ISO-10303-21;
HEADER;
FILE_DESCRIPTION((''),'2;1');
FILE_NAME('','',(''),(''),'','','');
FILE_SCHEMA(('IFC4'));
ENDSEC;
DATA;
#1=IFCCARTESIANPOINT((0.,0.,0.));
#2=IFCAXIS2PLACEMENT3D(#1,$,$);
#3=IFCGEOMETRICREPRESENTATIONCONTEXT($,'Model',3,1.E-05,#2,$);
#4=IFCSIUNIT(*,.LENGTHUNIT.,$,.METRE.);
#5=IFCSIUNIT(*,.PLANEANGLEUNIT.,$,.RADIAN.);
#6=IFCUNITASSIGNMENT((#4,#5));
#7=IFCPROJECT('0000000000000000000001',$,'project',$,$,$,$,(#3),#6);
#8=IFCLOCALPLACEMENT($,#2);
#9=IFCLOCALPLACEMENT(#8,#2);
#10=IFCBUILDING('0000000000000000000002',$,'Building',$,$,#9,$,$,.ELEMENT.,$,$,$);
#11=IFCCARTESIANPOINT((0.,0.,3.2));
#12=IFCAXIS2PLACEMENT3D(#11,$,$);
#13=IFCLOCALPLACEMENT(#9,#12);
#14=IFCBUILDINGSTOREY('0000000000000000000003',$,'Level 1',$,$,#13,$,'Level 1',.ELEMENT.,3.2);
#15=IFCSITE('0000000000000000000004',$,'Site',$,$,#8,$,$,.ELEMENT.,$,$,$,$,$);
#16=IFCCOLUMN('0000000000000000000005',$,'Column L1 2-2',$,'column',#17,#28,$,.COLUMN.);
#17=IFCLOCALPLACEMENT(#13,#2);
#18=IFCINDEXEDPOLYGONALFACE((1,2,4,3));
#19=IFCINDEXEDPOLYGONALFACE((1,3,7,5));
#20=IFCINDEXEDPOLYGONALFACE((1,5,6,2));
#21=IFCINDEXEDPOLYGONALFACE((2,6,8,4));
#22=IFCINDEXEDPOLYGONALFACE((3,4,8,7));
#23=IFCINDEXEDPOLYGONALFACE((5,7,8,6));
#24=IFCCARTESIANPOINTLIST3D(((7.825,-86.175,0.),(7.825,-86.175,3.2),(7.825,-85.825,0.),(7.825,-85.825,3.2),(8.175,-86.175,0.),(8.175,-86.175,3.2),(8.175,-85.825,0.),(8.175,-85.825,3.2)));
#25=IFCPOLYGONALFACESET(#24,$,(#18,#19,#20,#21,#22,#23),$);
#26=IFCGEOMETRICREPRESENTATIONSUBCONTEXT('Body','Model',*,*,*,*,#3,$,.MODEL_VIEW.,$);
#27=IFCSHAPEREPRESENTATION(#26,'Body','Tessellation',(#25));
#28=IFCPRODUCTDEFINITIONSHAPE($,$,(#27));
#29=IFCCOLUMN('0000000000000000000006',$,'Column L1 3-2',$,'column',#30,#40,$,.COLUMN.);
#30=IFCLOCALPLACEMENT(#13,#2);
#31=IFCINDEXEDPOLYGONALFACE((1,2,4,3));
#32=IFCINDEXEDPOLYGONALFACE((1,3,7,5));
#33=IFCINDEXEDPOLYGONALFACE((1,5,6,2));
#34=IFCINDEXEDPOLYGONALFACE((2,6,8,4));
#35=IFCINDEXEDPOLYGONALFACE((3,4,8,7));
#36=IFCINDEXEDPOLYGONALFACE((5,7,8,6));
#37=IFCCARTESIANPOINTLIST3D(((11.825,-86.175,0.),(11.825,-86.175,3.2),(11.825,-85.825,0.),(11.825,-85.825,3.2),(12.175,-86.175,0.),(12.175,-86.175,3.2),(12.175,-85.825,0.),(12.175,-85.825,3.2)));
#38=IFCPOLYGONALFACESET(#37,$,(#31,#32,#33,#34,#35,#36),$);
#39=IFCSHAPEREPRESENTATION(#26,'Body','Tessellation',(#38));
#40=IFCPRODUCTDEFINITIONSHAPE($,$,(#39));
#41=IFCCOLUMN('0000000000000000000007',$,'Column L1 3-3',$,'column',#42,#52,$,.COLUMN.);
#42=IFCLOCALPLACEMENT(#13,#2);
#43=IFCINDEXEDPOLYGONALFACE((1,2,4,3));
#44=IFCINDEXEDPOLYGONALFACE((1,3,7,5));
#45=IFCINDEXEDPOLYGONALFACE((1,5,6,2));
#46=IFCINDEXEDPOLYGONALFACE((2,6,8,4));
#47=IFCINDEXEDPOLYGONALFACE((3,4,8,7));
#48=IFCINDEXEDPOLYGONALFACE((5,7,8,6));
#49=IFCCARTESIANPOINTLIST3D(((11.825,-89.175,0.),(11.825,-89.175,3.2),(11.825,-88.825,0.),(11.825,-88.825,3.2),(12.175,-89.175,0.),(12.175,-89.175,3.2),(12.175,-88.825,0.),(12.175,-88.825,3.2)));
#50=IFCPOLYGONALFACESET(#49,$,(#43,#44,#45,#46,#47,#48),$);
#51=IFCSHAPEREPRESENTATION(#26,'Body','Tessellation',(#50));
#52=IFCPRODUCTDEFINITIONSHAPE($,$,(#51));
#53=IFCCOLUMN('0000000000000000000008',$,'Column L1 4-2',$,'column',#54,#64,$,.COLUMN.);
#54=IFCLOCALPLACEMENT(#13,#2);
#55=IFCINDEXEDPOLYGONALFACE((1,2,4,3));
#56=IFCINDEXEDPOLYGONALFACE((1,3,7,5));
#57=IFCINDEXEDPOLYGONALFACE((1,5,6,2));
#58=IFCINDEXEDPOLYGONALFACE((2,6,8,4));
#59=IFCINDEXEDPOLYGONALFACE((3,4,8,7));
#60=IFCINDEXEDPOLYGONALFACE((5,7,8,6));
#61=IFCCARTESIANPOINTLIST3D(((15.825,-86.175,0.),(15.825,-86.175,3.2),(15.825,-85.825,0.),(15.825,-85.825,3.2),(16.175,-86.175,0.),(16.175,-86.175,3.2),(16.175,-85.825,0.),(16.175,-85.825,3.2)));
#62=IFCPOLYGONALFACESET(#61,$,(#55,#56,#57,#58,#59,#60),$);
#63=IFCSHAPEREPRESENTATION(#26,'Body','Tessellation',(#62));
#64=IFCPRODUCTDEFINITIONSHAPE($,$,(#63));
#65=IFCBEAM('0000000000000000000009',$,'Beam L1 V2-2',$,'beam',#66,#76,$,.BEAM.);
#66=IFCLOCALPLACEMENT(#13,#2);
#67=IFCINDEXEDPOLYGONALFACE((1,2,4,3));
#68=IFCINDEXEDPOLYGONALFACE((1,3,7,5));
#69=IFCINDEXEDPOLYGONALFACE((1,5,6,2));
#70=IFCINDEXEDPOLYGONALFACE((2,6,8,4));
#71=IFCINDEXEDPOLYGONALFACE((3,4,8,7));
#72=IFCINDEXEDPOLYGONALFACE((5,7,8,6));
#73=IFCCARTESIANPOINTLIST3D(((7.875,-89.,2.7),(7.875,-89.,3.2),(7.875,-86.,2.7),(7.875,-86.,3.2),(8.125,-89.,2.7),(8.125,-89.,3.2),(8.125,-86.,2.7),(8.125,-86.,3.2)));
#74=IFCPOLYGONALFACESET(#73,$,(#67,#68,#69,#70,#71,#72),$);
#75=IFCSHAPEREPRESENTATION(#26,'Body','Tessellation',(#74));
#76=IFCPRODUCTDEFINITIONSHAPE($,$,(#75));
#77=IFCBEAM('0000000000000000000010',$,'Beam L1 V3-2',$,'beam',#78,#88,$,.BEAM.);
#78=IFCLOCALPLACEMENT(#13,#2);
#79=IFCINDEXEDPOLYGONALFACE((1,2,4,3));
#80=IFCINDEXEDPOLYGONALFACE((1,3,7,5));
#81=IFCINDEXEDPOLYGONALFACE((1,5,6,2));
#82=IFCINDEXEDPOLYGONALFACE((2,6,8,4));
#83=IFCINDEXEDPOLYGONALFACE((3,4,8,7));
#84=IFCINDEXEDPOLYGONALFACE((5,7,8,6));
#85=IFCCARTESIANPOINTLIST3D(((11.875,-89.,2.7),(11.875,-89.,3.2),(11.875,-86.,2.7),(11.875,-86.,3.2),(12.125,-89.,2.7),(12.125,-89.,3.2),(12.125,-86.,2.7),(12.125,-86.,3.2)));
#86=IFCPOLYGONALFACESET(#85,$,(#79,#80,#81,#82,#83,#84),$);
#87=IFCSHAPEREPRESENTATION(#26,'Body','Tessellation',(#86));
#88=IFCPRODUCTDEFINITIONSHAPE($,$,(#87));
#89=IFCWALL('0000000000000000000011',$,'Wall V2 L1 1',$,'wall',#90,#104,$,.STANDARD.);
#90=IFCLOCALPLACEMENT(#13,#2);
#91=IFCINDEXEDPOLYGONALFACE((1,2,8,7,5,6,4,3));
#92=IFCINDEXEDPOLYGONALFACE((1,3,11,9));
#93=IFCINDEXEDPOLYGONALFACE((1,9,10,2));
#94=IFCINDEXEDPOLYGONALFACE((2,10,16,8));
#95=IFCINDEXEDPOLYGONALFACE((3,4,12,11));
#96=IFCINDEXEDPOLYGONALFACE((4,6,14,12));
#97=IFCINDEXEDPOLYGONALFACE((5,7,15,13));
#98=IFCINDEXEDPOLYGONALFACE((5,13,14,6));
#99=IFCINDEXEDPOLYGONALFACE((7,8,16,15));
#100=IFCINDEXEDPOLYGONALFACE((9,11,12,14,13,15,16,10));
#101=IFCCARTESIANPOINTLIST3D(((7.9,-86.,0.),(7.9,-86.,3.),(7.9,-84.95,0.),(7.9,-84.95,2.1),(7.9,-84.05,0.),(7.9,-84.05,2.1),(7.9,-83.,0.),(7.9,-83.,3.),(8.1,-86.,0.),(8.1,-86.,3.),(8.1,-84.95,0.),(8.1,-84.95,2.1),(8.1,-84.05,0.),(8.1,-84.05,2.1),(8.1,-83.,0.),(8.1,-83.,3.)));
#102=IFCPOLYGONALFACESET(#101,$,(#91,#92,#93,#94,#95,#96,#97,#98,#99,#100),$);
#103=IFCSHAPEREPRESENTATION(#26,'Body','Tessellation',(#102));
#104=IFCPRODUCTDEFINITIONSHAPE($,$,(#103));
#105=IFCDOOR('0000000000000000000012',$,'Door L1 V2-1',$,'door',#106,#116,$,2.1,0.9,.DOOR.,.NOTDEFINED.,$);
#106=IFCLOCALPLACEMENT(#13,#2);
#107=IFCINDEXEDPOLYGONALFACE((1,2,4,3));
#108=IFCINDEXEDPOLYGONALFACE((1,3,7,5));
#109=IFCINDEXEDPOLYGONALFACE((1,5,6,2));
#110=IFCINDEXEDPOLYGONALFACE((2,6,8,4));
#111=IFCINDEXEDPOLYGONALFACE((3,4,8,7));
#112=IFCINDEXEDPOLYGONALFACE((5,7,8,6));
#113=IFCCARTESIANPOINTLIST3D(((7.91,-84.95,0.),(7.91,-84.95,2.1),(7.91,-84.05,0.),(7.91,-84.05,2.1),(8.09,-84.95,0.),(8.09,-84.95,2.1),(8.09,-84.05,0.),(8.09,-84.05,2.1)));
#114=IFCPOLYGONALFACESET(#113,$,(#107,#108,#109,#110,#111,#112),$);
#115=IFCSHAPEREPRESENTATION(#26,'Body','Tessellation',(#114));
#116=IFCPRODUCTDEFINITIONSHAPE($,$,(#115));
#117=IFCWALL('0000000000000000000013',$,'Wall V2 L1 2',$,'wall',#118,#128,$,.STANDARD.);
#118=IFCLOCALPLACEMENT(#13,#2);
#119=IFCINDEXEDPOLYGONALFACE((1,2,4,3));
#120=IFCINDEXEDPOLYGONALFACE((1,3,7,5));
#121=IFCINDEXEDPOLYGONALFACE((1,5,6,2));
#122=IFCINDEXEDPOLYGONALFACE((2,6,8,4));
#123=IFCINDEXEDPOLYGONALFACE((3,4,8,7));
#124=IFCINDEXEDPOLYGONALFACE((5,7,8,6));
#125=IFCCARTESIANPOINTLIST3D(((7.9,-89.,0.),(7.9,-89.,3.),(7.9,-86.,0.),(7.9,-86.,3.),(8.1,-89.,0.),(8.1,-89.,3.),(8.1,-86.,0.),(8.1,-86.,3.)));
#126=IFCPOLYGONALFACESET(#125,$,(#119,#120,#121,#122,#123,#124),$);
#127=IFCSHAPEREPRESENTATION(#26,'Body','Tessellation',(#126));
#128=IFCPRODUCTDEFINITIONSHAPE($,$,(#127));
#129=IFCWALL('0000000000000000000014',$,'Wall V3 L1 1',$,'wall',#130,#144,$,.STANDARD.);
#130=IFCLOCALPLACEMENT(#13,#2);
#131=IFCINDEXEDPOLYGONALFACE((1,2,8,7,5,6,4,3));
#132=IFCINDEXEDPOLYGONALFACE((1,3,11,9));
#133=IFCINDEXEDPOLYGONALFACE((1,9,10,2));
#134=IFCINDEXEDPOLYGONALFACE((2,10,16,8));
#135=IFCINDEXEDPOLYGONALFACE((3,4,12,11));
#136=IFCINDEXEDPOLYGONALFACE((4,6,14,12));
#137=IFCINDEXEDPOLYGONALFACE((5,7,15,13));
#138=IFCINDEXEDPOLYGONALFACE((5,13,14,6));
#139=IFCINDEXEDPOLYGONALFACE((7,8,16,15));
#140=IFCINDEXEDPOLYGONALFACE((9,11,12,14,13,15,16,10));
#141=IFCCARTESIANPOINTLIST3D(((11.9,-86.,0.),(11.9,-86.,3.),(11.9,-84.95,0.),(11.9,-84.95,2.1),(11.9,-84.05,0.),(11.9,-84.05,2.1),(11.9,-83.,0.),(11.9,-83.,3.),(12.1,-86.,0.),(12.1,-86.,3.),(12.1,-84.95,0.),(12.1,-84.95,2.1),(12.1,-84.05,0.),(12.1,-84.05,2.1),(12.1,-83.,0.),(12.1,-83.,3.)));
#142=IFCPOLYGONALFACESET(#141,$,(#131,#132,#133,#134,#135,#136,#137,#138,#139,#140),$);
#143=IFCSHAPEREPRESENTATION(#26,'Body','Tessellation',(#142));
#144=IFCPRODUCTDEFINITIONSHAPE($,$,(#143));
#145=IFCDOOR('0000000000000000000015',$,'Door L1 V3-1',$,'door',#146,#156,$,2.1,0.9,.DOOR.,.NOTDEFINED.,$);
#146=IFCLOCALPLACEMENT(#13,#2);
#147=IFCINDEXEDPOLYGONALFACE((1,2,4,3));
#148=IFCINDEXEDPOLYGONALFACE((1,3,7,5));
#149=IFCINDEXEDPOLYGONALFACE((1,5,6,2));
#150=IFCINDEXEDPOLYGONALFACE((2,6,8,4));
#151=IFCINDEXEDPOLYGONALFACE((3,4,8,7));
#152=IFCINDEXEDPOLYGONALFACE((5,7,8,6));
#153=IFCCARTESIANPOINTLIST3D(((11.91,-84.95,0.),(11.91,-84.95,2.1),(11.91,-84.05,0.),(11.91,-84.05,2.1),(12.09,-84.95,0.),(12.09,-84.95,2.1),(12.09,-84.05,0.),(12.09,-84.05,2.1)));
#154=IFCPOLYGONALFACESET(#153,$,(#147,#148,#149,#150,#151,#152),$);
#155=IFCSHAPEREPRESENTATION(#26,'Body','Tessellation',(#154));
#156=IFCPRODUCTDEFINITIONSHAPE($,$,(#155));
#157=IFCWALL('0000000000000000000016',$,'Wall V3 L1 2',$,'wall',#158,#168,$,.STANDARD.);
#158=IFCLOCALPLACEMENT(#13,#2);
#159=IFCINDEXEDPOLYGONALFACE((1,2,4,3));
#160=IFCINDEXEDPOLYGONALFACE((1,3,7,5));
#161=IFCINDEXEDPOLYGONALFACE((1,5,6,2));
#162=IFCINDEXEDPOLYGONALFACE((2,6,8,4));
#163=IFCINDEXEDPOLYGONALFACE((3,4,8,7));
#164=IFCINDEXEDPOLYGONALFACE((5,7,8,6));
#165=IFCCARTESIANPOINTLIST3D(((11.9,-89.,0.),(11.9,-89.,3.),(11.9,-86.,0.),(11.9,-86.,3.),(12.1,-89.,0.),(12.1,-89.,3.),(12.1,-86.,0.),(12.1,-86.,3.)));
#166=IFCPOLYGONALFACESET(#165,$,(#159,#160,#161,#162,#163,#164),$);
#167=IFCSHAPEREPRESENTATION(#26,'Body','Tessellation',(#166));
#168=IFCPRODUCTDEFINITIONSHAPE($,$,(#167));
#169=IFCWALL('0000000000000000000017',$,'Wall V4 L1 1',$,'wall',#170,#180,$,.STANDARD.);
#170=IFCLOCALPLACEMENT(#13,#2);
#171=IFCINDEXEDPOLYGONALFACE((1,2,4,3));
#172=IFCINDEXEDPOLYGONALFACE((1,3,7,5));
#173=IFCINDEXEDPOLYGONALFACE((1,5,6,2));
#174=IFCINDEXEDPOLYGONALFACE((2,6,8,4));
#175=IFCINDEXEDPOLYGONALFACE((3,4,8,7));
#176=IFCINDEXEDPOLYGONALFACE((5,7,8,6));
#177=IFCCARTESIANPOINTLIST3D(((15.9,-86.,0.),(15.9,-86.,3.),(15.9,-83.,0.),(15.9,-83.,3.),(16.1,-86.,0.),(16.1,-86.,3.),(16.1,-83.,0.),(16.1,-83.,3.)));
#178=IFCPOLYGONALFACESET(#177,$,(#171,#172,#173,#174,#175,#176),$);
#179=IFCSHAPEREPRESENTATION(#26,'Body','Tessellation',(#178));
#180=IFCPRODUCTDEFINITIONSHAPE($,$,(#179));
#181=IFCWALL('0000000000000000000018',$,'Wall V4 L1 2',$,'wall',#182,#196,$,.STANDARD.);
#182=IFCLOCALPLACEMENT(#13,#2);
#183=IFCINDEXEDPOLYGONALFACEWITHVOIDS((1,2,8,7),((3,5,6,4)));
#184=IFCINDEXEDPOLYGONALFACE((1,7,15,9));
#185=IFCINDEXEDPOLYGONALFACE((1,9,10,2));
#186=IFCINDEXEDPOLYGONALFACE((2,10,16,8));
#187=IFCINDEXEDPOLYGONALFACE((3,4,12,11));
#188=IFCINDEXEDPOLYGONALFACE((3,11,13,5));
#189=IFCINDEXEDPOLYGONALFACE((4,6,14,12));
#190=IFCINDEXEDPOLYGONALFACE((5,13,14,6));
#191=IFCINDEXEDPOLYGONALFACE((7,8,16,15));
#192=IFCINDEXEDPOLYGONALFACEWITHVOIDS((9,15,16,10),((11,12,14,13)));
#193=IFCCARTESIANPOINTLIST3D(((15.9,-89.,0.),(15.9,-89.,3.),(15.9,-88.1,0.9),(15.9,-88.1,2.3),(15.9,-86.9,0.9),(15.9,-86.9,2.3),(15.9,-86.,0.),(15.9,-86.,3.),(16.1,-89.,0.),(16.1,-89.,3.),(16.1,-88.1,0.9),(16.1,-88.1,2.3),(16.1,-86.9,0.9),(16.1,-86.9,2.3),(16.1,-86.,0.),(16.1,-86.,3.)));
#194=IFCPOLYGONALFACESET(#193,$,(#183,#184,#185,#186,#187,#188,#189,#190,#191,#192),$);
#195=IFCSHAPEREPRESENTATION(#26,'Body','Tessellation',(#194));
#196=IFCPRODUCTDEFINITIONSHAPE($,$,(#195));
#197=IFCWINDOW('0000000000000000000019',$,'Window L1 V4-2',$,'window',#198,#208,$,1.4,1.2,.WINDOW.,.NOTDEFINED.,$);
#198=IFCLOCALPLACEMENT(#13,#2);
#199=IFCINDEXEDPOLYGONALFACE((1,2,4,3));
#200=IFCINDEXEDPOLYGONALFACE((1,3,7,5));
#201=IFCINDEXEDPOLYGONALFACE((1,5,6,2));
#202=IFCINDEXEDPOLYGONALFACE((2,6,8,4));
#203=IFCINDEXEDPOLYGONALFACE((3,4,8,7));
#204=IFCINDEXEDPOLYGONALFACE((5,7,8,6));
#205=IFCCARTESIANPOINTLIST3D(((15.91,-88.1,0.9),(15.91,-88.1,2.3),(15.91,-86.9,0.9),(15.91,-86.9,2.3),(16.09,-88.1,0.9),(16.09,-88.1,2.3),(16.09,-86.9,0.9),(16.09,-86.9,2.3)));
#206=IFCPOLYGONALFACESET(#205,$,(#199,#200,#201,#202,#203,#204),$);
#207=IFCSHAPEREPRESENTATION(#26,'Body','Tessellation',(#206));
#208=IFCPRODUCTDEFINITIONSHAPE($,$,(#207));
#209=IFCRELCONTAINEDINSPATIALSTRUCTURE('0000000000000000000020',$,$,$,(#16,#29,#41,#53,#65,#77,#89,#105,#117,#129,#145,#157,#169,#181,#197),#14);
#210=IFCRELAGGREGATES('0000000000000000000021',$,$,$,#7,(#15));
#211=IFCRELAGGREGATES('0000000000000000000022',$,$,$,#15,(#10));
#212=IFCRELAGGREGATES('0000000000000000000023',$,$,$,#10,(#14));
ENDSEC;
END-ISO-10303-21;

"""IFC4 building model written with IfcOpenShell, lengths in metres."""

from ifc_helpers import new_model, si_unit, frame, frame_2d, origin, origin_2d, place, context, subcontext, project, spatial, rectangle, extrude, element, fill, save


model = new_model("IFC4")

# Units and contexts
model_context = context("Model", 3, precision=1e-05, world=origin())
body_context = subcontext(model_context, "Body", "Model", "MODEL_VIEW")
ifc_project = project(units=[si_unit("LENGTHUNIT", "METRE"), si_unit("PLANEANGLEUNIT", "RADIAN")], contexts=[model_context])

# Site, building, storey
site_placement = place(None, origin())
site = spatial("IfcSite", under=ifc_project, at=site_placement, Name="Site", CompositionType="ELEMENT")
building_placement = place(site_placement, origin())
building = spatial("IfcBuilding", under=site, at=building_placement, Name="Building", CompositionType="ELEMENT")
storey_placement = place(building_placement, frame((0.0, 0.0, 3.2)))
storey = spatial("IfcBuildingStorey", under=building, at=storey_placement, Name="Level 1", LongName="Level 1", CompositionType="ELEMENT", Elevation=3.2)

# Columns
for number, where, name in (
    (1, (8.0, -86.0, 0.0), "Column L1 2-2"),
    (2, (12.0, -86.0, 0.0), "Column L1 3-2"),
    (3, (12.0, -89.0, 0.0), "Column L1 3-3"),
    (4, (16.0, -86.0, 0.0), "Column L1 4-2"),
):
    element("IfcColumn", number, at=place(storey_placement, frame(where)), inside=storey, Name=name, ObjectType="column", PredefinedType="COLUMN", context=body_context, shape_type="SweptSolid", body=[
        extrude(rectangle(XDim=0.35, YDim=0.35, at=origin_2d()), origin(), (0.0, 0.0, 1.0), 3.2),
    ])

# Beams
for number, where, z_axis, x_axis, name in (
    (5, (8.0, -86.0, 2.95), (0.0, -1.0, 0.0), (0.0, 0.0, 1.0), "Beam L1 V2-2"),
    (6, (12.0, -86.0, 2.95), (0.0, -1.0, 0.0), (0.0, 0.0, 1.0), "Beam L1 V3-2"),
):
    element("IfcBeam", number, at=place(storey_placement, frame(where, z_axis=z_axis, x_axis=x_axis)), inside=storey, Name=name, ObjectType="beam", PredefinedType="BEAM", context=body_context, shape_type="SweptSolid", body=[
        extrude(rectangle(XDim=0.5, YDim=0.25, at=origin_2d()), origin(), (0.0, 0.0, 1.0), 3.0),
    ])

# Wall, opening, door
wall_1_placement = place(storey_placement, frame((8.0, -83.0, 0.0), z_axis=(0.0, 0.0, 1.0), x_axis=(0.0, -1.0, 0.0)))
wall_1 = element("IfcWall", 7, at=wall_1_placement, inside=storey, Name="Wall V2 L1 1", ObjectType="wall", PredefinedType="STANDARD", context=body_context, shape_type="SweptSolid", body=[
    extrude(rectangle(XDim=3.0, YDim=0.2, at=frame_2d((1.5, 0.0))), origin(), (0.0, 0.0, 1.0), 3.0),
])
opening_1_placement = place(storey_placement, frame((8.0, -84.5, 0.0), z_axis=(0.0, 0.0, 1.0), x_axis=(0.0, -1.0, 0.0)))
opening_1 = element("IfcOpeningElement", 8, at=opening_1_placement, cuts=wall_1, ObjectType="Opening", PredefinedType="OPENING", context=body_context, shape_type="SweptSolid", body=[
    extrude(rectangle(XDim=0.9, YDim=0.22, at=origin_2d()), origin(), (0.0, 0.0, 1.0), 2.1),
])
door_1_placement = place(storey_placement, frame((8.0, -84.5, 0.0), z_axis=(0.0, 0.0, 1.0), x_axis=(0.0, -1.0, 0.0)))
door_1 = element("IfcDoor", 9, at=door_1_placement, inside=storey, Name="Door L1 V2-1", ObjectType="door", OperationType="NOTDEFINED", OverallHeight=2.1, OverallWidth=0.9, PredefinedType="DOOR", context=body_context, shape_type="SweptSolid", body=[
    extrude(rectangle(XDim=0.9, YDim=0.18, at=origin_2d()), origin(), (0.0, 0.0, 1.0), 2.1),
])
fill(opening_1, door_1)

# Wall
wall_2_placement = place(storey_placement, frame((8.0, -86.0, 0.0), z_axis=(0.0, 0.0, 1.0), x_axis=(0.0, -1.0, 0.0)))
element("IfcWall", 10, at=wall_2_placement, inside=storey, Name="Wall V2 L1 2", ObjectType="wall", PredefinedType="STANDARD", context=body_context, shape_type="SweptSolid", body=[
    extrude(rectangle(XDim=3.0, YDim=0.2, at=frame_2d((1.5, 0.0))), origin(), (0.0, 0.0, 1.0), 3.0),
])

# Wall, opening, door
wall_3_placement = place(storey_placement, frame((12.0, -83.0, 0.0), z_axis=(0.0, 0.0, 1.0), x_axis=(0.0, -1.0, 0.0)))
wall_3 = element("IfcWall", 11, at=wall_3_placement, inside=storey, Name="Wall V3 L1 1", ObjectType="wall", PredefinedType="STANDARD", context=body_context, shape_type="SweptSolid", body=[
    extrude(rectangle(XDim=3.0, YDim=0.2, at=frame_2d((1.5, 0.0))), origin(), (0.0, 0.0, 1.0), 3.0),
])
opening_2_placement = place(storey_placement, frame((12.0, -84.5, 0.0), z_axis=(0.0, 0.0, 1.0), x_axis=(0.0, -1.0, 0.0)))
opening_2 = element("IfcOpeningElement", 12, at=opening_2_placement, cuts=wall_3, ObjectType="Opening", PredefinedType="OPENING", context=body_context, shape_type="SweptSolid", body=[
    extrude(rectangle(XDim=0.9, YDim=0.22, at=origin_2d()), origin(), (0.0, 0.0, 1.0), 2.1),
])
door_2_placement = place(storey_placement, frame((12.0, -84.5, 0.0), z_axis=(0.0, 0.0, 1.0), x_axis=(0.0, -1.0, 0.0)))
door_2 = element("IfcDoor", 13, at=door_2_placement, inside=storey, Name="Door L1 V3-1", ObjectType="door", OperationType="NOTDEFINED", OverallHeight=2.1, OverallWidth=0.9, PredefinedType="DOOR", context=body_context, shape_type="SweptSolid", body=[
    extrude(rectangle(XDim=0.9, YDim=0.18, at=origin_2d()), origin(), (0.0, 0.0, 1.0), 2.1),
])
fill(opening_2, door_2)

# Walls
for number, where, z_axis, x_axis, name in (
    (14, (12.0, -86.0, 0.0), (0.0, 0.0, 1.0), (0.0, -1.0, 0.0), "Wall V3 L1 2"),
    (15, (16.0, -83.0, 0.0), (0.0, 0.0, 1.0), (0.0, -1.0, 0.0), "Wall V4 L1 1"),
):
    element("IfcWall", number, at=place(storey_placement, frame(where, z_axis=z_axis, x_axis=x_axis)), inside=storey, Name=name, ObjectType="wall", PredefinedType="STANDARD", context=body_context, shape_type="SweptSolid", body=[
        extrude(rectangle(XDim=3.0, YDim=0.2, at=frame_2d((1.5, 0.0))), origin(), (0.0, 0.0, 1.0), 3.0),
    ])

# Wall, opening, window
wall_4_placement = place(storey_placement, frame((16.0, -86.0, 0.0), z_axis=(0.0, 0.0, 1.0), x_axis=(0.0, -1.0, 0.0)))
wall_4 = element("IfcWall", 16, at=wall_4_placement, inside=storey, Name="Wall V4 L1 2", ObjectType="wall", PredefinedType="STANDARD", context=body_context, shape_type="SweptSolid", body=[
    extrude(rectangle(XDim=3.0, YDim=0.2, at=frame_2d((1.5, 0.0))), origin(), (0.0, 0.0, 1.0), 3.0),
])
opening_3_placement = place(storey_placement, frame((16.0, -87.5, 0.9), z_axis=(0.0, 0.0, 1.0), x_axis=(0.0, -1.0, 0.0)))
opening_3 = element("IfcOpeningElement", 17, at=opening_3_placement, cuts=wall_4, ObjectType="Opening", PredefinedType="OPENING", context=body_context, shape_type="SweptSolid", body=[
    extrude(rectangle(XDim=1.2, YDim=0.22, at=origin_2d()), origin(), (0.0, 0.0, 1.0), 1.4),
])
window_1_placement = place(storey_placement, frame((16.0, -87.5, 0.9), z_axis=(0.0, 0.0, 1.0), x_axis=(0.0, -1.0, 0.0)))
window_1 = element("IfcWindow", 18, at=window_1_placement, inside=storey, Name="Window L1 V4-2", ObjectType="window", OverallHeight=1.4, OverallWidth=1.2, PartitioningType="NOTDEFINED", PredefinedType="WINDOW", context=body_context, shape_type="SweptSolid", body=[
    extrude(rectangle(XDim=1.2, YDim=0.18, at=origin_2d()), origin(), (0.0, 0.0, 1.0), 1.4),
])
fill(opening_3, window_1)

save(model, "model.ifc")
